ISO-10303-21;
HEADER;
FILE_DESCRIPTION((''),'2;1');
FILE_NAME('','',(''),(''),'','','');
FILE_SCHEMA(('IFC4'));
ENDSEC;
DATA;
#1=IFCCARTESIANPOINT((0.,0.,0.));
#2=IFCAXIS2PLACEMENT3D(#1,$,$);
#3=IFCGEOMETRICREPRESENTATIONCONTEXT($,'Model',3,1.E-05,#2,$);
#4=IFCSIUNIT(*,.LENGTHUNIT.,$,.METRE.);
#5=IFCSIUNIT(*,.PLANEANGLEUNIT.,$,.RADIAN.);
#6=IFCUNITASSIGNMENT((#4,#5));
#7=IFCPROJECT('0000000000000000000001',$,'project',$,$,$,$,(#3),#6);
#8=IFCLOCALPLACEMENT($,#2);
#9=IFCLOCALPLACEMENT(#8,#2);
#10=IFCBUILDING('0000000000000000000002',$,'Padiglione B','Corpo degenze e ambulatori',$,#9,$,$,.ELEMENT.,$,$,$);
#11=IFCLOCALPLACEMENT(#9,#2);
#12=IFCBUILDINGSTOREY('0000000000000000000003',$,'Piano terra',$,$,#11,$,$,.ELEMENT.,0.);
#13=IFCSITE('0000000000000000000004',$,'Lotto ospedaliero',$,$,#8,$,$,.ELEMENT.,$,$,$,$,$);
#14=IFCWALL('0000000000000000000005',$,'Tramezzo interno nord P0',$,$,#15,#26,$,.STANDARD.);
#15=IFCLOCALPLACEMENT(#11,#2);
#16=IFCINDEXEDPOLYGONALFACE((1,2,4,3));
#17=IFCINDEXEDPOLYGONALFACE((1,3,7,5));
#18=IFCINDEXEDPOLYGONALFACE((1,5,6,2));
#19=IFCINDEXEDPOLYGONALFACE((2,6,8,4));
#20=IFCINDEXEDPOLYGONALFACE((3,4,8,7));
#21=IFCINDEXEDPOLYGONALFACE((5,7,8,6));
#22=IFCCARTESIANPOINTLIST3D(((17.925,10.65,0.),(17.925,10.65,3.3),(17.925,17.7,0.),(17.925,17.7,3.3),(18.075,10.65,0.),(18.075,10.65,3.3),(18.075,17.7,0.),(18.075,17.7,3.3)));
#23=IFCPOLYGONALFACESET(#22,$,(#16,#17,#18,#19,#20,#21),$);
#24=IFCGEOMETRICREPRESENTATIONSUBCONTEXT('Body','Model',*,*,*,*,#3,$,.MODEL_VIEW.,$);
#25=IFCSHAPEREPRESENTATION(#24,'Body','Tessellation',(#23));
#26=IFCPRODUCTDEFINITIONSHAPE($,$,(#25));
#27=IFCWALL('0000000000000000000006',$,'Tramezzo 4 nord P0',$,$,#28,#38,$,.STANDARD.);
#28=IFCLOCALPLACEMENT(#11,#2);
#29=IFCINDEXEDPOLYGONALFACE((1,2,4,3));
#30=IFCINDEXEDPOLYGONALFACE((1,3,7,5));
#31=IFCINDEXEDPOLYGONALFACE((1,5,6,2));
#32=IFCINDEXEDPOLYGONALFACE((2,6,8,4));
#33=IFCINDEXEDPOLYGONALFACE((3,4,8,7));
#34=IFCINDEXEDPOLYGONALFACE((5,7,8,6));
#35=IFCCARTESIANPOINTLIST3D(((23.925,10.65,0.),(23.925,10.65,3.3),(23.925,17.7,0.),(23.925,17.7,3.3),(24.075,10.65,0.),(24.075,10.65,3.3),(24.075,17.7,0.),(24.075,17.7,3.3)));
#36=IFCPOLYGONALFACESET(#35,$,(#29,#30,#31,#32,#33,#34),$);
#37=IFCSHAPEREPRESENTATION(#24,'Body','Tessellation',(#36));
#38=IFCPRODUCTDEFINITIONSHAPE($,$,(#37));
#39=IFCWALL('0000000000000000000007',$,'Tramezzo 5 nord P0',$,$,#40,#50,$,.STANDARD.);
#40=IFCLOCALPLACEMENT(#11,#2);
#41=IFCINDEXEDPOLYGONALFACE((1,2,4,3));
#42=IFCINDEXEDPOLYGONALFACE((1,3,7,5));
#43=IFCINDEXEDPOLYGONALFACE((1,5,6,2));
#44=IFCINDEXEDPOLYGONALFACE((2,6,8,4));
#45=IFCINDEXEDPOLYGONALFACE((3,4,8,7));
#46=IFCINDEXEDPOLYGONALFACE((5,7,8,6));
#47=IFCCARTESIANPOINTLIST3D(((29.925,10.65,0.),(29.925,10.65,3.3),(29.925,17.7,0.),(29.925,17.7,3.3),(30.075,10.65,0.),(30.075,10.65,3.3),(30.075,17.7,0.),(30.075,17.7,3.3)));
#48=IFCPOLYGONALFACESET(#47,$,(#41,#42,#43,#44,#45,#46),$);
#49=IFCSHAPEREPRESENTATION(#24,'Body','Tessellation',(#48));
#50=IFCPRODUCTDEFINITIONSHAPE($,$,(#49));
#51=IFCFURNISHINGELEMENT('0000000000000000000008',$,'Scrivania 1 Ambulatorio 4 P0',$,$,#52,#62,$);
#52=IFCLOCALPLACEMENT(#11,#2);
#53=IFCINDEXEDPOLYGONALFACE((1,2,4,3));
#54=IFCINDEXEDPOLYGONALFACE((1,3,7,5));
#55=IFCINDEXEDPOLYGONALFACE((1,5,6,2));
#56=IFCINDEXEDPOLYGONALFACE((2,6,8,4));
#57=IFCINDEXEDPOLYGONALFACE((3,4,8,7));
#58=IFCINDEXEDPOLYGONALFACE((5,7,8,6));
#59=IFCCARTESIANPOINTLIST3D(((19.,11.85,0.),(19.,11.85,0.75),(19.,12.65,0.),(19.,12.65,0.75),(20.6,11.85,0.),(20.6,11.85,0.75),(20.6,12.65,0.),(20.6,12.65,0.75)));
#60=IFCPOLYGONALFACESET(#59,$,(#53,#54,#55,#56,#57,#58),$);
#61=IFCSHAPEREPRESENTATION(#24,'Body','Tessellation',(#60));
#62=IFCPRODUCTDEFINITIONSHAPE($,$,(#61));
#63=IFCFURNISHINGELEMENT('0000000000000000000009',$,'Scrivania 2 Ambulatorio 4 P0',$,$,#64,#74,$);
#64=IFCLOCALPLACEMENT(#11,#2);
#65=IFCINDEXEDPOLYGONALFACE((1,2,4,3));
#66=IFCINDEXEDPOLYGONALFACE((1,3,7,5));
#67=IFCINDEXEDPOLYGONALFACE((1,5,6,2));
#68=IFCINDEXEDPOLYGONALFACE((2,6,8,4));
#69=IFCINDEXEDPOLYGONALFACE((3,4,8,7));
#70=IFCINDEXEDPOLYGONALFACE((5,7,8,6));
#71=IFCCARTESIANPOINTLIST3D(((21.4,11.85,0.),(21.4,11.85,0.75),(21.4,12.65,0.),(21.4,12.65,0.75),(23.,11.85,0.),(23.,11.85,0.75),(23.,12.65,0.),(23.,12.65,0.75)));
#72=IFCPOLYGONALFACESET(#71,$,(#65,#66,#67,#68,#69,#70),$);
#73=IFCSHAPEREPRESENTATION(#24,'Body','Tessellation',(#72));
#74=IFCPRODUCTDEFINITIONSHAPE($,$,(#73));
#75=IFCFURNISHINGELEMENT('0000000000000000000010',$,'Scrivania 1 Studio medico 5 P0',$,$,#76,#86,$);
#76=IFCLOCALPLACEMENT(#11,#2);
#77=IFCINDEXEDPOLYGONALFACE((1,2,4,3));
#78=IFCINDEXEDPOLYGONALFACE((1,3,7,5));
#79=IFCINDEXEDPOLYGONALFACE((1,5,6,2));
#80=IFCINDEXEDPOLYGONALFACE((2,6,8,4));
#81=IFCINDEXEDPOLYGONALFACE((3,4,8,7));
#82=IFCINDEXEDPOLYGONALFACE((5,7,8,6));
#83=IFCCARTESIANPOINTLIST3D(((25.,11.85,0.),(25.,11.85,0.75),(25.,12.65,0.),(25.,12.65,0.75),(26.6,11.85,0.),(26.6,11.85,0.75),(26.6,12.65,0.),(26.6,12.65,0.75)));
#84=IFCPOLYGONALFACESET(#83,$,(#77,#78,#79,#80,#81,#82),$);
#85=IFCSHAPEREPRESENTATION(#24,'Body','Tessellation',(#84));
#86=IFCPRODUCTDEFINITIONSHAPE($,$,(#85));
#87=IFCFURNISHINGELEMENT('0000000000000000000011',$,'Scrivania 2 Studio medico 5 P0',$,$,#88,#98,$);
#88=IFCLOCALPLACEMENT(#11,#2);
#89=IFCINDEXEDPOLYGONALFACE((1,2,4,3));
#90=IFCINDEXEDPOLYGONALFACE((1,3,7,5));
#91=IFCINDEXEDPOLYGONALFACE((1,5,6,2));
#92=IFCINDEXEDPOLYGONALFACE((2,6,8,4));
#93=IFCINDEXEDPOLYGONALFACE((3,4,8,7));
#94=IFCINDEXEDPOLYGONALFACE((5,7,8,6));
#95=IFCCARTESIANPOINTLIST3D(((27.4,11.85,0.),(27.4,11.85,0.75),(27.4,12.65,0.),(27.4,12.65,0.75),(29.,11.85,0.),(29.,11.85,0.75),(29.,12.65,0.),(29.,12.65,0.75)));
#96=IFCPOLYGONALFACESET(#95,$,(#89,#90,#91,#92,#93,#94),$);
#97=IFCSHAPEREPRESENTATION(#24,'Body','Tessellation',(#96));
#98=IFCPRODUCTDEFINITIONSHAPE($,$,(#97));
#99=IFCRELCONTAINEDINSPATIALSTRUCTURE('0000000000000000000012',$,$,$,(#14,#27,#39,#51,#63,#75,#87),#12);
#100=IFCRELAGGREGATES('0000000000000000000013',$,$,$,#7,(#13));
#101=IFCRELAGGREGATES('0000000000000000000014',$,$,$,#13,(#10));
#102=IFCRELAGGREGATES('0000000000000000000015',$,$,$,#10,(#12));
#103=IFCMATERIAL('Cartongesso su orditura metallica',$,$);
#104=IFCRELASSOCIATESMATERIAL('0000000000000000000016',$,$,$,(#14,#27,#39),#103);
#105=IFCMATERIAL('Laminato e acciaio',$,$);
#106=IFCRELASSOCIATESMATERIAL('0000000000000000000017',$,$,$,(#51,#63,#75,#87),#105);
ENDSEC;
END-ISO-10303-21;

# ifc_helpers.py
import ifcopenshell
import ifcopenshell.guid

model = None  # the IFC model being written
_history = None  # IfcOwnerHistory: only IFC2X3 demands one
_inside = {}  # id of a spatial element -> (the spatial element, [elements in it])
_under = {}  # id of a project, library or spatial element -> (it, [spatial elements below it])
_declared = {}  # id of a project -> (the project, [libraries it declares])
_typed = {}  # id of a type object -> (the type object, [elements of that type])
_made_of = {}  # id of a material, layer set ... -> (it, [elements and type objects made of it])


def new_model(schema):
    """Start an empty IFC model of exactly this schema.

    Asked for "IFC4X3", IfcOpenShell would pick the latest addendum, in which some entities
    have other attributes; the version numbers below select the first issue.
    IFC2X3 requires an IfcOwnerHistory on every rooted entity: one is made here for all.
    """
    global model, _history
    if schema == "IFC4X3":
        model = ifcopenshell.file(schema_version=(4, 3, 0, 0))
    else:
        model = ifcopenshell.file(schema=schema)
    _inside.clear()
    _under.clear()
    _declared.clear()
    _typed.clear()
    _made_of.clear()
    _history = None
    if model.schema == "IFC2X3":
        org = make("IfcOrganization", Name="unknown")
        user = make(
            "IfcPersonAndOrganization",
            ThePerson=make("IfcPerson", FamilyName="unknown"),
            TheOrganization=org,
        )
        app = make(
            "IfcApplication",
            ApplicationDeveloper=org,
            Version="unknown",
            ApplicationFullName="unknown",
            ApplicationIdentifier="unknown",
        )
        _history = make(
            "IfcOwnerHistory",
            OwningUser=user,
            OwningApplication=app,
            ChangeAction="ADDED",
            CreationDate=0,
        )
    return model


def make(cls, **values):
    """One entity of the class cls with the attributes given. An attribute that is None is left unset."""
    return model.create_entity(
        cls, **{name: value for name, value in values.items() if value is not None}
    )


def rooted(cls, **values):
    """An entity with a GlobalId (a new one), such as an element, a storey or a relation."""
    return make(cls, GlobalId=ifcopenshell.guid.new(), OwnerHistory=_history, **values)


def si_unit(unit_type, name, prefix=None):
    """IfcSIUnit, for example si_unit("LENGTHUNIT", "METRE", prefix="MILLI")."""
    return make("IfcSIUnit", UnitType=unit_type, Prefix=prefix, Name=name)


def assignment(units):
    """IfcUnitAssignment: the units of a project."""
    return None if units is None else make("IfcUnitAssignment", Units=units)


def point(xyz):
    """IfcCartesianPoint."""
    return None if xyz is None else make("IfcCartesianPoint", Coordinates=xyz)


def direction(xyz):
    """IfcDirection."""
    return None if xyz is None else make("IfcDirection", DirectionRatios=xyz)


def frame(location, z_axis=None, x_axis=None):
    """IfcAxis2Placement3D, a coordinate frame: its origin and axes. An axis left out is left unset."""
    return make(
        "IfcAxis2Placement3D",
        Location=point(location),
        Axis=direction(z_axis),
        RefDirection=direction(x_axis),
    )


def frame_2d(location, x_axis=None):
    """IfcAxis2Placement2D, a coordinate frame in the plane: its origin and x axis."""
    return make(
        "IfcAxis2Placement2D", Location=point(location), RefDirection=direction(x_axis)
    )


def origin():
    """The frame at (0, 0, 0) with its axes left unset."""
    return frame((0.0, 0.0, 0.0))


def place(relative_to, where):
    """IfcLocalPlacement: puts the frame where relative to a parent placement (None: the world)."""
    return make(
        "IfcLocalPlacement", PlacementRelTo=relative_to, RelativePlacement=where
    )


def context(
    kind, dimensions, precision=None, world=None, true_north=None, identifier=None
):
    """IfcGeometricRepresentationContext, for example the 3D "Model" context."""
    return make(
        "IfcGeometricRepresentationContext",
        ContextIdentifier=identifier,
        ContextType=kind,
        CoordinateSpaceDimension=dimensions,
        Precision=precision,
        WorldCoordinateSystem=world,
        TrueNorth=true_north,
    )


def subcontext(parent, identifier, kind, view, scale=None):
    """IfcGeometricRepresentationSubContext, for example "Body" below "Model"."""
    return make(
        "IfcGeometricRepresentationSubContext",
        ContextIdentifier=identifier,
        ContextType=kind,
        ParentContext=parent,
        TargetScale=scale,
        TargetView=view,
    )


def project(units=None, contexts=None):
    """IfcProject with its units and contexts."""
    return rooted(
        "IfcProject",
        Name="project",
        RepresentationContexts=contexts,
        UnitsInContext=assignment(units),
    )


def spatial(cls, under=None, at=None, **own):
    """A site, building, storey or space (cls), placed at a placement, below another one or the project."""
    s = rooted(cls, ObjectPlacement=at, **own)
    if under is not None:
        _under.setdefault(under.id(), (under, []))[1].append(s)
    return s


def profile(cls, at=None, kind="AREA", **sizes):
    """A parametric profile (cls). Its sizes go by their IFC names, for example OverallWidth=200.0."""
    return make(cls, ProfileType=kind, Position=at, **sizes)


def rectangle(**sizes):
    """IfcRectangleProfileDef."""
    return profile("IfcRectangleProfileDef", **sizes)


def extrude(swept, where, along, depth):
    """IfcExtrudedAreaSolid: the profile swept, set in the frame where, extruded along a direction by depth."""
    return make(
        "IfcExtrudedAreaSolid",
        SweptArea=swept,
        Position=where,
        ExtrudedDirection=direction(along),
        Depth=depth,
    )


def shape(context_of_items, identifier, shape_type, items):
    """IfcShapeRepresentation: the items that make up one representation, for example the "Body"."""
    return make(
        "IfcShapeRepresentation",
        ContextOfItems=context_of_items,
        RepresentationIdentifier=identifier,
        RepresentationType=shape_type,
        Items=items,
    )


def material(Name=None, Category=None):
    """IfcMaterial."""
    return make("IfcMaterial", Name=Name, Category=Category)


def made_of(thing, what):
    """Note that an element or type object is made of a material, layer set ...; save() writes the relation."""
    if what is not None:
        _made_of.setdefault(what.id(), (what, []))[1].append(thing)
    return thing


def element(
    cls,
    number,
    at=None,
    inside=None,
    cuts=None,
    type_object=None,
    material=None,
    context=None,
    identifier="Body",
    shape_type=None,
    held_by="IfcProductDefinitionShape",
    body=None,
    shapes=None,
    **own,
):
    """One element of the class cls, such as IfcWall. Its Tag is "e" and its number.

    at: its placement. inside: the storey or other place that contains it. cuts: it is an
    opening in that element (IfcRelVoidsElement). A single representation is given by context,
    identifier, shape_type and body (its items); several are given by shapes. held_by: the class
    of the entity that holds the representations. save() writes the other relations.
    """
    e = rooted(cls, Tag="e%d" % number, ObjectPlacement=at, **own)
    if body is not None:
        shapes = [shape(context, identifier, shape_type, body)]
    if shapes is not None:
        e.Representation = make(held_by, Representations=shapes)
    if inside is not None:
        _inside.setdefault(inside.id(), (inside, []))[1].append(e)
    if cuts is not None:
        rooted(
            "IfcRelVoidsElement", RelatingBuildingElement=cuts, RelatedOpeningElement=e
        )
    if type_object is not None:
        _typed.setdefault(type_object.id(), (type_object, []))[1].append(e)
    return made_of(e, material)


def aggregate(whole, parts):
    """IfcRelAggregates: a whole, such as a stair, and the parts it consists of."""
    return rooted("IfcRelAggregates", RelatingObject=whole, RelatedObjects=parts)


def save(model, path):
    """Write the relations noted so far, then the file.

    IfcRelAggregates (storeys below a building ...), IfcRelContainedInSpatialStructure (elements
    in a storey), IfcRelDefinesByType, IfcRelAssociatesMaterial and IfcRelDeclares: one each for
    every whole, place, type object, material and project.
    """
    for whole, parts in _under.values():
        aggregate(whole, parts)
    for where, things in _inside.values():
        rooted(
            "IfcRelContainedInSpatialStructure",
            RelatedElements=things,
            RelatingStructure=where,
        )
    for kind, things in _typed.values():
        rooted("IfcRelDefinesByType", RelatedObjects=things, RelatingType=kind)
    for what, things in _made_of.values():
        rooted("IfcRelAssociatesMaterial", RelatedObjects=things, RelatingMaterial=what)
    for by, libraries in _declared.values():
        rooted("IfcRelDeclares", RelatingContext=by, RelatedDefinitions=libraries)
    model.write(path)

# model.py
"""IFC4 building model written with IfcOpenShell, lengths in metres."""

from ifc_helpers import new_model, si_unit, frame, frame_2d, origin, place, context, subcontext, project, spatial, rectangle, extrude, material, element, save


model = new_model("IFC4")

# Units and contexts
model_context = context("Model", 3, precision=1e-05, world=origin())
body_context = subcontext(model_context, "Body", "Model", "MODEL_VIEW")
ifc_project = project(units=[si_unit("LENGTHUNIT", "METRE"), si_unit("PLANEANGLEUNIT", "RADIAN")], contexts=[model_context])

# Site, building, storey
site_placement = place(None, origin())
site = spatial("IfcSite", under=ifc_project, at=site_placement, Name="Lotto ospedaliero", CompositionType="ELEMENT")
building_placement = place(site_placement, origin())
building = spatial("IfcBuilding", under=site, at=building_placement, Name="Padiglione B", Description="Corpo degenze e ambulatori", CompositionType="ELEMENT")
storey_placement = place(building_placement, origin())
storey = spatial("IfcBuildingStorey", under=building, at=storey_placement, Name="Piano terra", CompositionType="ELEMENT", Elevation=0.0)

# Walls
ifc_material_1 = material(Name="Cartongesso su orditura metallica")
for number, where, name in (
    (1, (17.925, 10.65, 0.0), "Tramezzo interno nord P0"),
    (2, (23.925, 10.65, 0.0), "Tramezzo 4 nord P0"),
    (3, (29.925, 10.65, 0.0), "Tramezzo 5 nord P0"),
):
    element("IfcWall", number, at=place(storey_placement, frame(where)), inside=storey, material=ifc_material_1, Name=name, PredefinedType="STANDARD", context=body_context, shape_type="SweptSolid", body=[
        extrude(rectangle(XDim=0.15, YDim=7.05, at=frame_2d((0.075, 3.525))), origin(), (0.0, 0.0, 1.0), 3.3),
    ])

# Furnishing elements
ifc_material_2 = material(Name="Laminato e acciaio")
for number, where, name in (
    (4, (19.0, 11.85, 0.0), "Scrivania 1 Ambulatorio 4 P0"),
    (5, (21.4, 11.85, 0.0), "Scrivania 2 Ambulatorio 4 P0"),
    (6, (25.0, 11.85, 0.0), "Scrivania 1 Studio medico 5 P0"),
    (7, (27.4, 11.85, 0.0), "Scrivania 2 Studio medico 5 P0"),
):
    element("IfcFurnishingElement", number, at=place(storey_placement, frame(where)), inside=storey, material=ifc_material_2, Name=name, context=body_context, shape_type="SweptSolid", body=[
        extrude(rectangle(XDim=1.6, YDim=0.8, at=frame_2d((0.8, 0.4))), origin(), (0.0, 0.0, 1.0), 0.75),
    ])

save(model, "model.ifc")
